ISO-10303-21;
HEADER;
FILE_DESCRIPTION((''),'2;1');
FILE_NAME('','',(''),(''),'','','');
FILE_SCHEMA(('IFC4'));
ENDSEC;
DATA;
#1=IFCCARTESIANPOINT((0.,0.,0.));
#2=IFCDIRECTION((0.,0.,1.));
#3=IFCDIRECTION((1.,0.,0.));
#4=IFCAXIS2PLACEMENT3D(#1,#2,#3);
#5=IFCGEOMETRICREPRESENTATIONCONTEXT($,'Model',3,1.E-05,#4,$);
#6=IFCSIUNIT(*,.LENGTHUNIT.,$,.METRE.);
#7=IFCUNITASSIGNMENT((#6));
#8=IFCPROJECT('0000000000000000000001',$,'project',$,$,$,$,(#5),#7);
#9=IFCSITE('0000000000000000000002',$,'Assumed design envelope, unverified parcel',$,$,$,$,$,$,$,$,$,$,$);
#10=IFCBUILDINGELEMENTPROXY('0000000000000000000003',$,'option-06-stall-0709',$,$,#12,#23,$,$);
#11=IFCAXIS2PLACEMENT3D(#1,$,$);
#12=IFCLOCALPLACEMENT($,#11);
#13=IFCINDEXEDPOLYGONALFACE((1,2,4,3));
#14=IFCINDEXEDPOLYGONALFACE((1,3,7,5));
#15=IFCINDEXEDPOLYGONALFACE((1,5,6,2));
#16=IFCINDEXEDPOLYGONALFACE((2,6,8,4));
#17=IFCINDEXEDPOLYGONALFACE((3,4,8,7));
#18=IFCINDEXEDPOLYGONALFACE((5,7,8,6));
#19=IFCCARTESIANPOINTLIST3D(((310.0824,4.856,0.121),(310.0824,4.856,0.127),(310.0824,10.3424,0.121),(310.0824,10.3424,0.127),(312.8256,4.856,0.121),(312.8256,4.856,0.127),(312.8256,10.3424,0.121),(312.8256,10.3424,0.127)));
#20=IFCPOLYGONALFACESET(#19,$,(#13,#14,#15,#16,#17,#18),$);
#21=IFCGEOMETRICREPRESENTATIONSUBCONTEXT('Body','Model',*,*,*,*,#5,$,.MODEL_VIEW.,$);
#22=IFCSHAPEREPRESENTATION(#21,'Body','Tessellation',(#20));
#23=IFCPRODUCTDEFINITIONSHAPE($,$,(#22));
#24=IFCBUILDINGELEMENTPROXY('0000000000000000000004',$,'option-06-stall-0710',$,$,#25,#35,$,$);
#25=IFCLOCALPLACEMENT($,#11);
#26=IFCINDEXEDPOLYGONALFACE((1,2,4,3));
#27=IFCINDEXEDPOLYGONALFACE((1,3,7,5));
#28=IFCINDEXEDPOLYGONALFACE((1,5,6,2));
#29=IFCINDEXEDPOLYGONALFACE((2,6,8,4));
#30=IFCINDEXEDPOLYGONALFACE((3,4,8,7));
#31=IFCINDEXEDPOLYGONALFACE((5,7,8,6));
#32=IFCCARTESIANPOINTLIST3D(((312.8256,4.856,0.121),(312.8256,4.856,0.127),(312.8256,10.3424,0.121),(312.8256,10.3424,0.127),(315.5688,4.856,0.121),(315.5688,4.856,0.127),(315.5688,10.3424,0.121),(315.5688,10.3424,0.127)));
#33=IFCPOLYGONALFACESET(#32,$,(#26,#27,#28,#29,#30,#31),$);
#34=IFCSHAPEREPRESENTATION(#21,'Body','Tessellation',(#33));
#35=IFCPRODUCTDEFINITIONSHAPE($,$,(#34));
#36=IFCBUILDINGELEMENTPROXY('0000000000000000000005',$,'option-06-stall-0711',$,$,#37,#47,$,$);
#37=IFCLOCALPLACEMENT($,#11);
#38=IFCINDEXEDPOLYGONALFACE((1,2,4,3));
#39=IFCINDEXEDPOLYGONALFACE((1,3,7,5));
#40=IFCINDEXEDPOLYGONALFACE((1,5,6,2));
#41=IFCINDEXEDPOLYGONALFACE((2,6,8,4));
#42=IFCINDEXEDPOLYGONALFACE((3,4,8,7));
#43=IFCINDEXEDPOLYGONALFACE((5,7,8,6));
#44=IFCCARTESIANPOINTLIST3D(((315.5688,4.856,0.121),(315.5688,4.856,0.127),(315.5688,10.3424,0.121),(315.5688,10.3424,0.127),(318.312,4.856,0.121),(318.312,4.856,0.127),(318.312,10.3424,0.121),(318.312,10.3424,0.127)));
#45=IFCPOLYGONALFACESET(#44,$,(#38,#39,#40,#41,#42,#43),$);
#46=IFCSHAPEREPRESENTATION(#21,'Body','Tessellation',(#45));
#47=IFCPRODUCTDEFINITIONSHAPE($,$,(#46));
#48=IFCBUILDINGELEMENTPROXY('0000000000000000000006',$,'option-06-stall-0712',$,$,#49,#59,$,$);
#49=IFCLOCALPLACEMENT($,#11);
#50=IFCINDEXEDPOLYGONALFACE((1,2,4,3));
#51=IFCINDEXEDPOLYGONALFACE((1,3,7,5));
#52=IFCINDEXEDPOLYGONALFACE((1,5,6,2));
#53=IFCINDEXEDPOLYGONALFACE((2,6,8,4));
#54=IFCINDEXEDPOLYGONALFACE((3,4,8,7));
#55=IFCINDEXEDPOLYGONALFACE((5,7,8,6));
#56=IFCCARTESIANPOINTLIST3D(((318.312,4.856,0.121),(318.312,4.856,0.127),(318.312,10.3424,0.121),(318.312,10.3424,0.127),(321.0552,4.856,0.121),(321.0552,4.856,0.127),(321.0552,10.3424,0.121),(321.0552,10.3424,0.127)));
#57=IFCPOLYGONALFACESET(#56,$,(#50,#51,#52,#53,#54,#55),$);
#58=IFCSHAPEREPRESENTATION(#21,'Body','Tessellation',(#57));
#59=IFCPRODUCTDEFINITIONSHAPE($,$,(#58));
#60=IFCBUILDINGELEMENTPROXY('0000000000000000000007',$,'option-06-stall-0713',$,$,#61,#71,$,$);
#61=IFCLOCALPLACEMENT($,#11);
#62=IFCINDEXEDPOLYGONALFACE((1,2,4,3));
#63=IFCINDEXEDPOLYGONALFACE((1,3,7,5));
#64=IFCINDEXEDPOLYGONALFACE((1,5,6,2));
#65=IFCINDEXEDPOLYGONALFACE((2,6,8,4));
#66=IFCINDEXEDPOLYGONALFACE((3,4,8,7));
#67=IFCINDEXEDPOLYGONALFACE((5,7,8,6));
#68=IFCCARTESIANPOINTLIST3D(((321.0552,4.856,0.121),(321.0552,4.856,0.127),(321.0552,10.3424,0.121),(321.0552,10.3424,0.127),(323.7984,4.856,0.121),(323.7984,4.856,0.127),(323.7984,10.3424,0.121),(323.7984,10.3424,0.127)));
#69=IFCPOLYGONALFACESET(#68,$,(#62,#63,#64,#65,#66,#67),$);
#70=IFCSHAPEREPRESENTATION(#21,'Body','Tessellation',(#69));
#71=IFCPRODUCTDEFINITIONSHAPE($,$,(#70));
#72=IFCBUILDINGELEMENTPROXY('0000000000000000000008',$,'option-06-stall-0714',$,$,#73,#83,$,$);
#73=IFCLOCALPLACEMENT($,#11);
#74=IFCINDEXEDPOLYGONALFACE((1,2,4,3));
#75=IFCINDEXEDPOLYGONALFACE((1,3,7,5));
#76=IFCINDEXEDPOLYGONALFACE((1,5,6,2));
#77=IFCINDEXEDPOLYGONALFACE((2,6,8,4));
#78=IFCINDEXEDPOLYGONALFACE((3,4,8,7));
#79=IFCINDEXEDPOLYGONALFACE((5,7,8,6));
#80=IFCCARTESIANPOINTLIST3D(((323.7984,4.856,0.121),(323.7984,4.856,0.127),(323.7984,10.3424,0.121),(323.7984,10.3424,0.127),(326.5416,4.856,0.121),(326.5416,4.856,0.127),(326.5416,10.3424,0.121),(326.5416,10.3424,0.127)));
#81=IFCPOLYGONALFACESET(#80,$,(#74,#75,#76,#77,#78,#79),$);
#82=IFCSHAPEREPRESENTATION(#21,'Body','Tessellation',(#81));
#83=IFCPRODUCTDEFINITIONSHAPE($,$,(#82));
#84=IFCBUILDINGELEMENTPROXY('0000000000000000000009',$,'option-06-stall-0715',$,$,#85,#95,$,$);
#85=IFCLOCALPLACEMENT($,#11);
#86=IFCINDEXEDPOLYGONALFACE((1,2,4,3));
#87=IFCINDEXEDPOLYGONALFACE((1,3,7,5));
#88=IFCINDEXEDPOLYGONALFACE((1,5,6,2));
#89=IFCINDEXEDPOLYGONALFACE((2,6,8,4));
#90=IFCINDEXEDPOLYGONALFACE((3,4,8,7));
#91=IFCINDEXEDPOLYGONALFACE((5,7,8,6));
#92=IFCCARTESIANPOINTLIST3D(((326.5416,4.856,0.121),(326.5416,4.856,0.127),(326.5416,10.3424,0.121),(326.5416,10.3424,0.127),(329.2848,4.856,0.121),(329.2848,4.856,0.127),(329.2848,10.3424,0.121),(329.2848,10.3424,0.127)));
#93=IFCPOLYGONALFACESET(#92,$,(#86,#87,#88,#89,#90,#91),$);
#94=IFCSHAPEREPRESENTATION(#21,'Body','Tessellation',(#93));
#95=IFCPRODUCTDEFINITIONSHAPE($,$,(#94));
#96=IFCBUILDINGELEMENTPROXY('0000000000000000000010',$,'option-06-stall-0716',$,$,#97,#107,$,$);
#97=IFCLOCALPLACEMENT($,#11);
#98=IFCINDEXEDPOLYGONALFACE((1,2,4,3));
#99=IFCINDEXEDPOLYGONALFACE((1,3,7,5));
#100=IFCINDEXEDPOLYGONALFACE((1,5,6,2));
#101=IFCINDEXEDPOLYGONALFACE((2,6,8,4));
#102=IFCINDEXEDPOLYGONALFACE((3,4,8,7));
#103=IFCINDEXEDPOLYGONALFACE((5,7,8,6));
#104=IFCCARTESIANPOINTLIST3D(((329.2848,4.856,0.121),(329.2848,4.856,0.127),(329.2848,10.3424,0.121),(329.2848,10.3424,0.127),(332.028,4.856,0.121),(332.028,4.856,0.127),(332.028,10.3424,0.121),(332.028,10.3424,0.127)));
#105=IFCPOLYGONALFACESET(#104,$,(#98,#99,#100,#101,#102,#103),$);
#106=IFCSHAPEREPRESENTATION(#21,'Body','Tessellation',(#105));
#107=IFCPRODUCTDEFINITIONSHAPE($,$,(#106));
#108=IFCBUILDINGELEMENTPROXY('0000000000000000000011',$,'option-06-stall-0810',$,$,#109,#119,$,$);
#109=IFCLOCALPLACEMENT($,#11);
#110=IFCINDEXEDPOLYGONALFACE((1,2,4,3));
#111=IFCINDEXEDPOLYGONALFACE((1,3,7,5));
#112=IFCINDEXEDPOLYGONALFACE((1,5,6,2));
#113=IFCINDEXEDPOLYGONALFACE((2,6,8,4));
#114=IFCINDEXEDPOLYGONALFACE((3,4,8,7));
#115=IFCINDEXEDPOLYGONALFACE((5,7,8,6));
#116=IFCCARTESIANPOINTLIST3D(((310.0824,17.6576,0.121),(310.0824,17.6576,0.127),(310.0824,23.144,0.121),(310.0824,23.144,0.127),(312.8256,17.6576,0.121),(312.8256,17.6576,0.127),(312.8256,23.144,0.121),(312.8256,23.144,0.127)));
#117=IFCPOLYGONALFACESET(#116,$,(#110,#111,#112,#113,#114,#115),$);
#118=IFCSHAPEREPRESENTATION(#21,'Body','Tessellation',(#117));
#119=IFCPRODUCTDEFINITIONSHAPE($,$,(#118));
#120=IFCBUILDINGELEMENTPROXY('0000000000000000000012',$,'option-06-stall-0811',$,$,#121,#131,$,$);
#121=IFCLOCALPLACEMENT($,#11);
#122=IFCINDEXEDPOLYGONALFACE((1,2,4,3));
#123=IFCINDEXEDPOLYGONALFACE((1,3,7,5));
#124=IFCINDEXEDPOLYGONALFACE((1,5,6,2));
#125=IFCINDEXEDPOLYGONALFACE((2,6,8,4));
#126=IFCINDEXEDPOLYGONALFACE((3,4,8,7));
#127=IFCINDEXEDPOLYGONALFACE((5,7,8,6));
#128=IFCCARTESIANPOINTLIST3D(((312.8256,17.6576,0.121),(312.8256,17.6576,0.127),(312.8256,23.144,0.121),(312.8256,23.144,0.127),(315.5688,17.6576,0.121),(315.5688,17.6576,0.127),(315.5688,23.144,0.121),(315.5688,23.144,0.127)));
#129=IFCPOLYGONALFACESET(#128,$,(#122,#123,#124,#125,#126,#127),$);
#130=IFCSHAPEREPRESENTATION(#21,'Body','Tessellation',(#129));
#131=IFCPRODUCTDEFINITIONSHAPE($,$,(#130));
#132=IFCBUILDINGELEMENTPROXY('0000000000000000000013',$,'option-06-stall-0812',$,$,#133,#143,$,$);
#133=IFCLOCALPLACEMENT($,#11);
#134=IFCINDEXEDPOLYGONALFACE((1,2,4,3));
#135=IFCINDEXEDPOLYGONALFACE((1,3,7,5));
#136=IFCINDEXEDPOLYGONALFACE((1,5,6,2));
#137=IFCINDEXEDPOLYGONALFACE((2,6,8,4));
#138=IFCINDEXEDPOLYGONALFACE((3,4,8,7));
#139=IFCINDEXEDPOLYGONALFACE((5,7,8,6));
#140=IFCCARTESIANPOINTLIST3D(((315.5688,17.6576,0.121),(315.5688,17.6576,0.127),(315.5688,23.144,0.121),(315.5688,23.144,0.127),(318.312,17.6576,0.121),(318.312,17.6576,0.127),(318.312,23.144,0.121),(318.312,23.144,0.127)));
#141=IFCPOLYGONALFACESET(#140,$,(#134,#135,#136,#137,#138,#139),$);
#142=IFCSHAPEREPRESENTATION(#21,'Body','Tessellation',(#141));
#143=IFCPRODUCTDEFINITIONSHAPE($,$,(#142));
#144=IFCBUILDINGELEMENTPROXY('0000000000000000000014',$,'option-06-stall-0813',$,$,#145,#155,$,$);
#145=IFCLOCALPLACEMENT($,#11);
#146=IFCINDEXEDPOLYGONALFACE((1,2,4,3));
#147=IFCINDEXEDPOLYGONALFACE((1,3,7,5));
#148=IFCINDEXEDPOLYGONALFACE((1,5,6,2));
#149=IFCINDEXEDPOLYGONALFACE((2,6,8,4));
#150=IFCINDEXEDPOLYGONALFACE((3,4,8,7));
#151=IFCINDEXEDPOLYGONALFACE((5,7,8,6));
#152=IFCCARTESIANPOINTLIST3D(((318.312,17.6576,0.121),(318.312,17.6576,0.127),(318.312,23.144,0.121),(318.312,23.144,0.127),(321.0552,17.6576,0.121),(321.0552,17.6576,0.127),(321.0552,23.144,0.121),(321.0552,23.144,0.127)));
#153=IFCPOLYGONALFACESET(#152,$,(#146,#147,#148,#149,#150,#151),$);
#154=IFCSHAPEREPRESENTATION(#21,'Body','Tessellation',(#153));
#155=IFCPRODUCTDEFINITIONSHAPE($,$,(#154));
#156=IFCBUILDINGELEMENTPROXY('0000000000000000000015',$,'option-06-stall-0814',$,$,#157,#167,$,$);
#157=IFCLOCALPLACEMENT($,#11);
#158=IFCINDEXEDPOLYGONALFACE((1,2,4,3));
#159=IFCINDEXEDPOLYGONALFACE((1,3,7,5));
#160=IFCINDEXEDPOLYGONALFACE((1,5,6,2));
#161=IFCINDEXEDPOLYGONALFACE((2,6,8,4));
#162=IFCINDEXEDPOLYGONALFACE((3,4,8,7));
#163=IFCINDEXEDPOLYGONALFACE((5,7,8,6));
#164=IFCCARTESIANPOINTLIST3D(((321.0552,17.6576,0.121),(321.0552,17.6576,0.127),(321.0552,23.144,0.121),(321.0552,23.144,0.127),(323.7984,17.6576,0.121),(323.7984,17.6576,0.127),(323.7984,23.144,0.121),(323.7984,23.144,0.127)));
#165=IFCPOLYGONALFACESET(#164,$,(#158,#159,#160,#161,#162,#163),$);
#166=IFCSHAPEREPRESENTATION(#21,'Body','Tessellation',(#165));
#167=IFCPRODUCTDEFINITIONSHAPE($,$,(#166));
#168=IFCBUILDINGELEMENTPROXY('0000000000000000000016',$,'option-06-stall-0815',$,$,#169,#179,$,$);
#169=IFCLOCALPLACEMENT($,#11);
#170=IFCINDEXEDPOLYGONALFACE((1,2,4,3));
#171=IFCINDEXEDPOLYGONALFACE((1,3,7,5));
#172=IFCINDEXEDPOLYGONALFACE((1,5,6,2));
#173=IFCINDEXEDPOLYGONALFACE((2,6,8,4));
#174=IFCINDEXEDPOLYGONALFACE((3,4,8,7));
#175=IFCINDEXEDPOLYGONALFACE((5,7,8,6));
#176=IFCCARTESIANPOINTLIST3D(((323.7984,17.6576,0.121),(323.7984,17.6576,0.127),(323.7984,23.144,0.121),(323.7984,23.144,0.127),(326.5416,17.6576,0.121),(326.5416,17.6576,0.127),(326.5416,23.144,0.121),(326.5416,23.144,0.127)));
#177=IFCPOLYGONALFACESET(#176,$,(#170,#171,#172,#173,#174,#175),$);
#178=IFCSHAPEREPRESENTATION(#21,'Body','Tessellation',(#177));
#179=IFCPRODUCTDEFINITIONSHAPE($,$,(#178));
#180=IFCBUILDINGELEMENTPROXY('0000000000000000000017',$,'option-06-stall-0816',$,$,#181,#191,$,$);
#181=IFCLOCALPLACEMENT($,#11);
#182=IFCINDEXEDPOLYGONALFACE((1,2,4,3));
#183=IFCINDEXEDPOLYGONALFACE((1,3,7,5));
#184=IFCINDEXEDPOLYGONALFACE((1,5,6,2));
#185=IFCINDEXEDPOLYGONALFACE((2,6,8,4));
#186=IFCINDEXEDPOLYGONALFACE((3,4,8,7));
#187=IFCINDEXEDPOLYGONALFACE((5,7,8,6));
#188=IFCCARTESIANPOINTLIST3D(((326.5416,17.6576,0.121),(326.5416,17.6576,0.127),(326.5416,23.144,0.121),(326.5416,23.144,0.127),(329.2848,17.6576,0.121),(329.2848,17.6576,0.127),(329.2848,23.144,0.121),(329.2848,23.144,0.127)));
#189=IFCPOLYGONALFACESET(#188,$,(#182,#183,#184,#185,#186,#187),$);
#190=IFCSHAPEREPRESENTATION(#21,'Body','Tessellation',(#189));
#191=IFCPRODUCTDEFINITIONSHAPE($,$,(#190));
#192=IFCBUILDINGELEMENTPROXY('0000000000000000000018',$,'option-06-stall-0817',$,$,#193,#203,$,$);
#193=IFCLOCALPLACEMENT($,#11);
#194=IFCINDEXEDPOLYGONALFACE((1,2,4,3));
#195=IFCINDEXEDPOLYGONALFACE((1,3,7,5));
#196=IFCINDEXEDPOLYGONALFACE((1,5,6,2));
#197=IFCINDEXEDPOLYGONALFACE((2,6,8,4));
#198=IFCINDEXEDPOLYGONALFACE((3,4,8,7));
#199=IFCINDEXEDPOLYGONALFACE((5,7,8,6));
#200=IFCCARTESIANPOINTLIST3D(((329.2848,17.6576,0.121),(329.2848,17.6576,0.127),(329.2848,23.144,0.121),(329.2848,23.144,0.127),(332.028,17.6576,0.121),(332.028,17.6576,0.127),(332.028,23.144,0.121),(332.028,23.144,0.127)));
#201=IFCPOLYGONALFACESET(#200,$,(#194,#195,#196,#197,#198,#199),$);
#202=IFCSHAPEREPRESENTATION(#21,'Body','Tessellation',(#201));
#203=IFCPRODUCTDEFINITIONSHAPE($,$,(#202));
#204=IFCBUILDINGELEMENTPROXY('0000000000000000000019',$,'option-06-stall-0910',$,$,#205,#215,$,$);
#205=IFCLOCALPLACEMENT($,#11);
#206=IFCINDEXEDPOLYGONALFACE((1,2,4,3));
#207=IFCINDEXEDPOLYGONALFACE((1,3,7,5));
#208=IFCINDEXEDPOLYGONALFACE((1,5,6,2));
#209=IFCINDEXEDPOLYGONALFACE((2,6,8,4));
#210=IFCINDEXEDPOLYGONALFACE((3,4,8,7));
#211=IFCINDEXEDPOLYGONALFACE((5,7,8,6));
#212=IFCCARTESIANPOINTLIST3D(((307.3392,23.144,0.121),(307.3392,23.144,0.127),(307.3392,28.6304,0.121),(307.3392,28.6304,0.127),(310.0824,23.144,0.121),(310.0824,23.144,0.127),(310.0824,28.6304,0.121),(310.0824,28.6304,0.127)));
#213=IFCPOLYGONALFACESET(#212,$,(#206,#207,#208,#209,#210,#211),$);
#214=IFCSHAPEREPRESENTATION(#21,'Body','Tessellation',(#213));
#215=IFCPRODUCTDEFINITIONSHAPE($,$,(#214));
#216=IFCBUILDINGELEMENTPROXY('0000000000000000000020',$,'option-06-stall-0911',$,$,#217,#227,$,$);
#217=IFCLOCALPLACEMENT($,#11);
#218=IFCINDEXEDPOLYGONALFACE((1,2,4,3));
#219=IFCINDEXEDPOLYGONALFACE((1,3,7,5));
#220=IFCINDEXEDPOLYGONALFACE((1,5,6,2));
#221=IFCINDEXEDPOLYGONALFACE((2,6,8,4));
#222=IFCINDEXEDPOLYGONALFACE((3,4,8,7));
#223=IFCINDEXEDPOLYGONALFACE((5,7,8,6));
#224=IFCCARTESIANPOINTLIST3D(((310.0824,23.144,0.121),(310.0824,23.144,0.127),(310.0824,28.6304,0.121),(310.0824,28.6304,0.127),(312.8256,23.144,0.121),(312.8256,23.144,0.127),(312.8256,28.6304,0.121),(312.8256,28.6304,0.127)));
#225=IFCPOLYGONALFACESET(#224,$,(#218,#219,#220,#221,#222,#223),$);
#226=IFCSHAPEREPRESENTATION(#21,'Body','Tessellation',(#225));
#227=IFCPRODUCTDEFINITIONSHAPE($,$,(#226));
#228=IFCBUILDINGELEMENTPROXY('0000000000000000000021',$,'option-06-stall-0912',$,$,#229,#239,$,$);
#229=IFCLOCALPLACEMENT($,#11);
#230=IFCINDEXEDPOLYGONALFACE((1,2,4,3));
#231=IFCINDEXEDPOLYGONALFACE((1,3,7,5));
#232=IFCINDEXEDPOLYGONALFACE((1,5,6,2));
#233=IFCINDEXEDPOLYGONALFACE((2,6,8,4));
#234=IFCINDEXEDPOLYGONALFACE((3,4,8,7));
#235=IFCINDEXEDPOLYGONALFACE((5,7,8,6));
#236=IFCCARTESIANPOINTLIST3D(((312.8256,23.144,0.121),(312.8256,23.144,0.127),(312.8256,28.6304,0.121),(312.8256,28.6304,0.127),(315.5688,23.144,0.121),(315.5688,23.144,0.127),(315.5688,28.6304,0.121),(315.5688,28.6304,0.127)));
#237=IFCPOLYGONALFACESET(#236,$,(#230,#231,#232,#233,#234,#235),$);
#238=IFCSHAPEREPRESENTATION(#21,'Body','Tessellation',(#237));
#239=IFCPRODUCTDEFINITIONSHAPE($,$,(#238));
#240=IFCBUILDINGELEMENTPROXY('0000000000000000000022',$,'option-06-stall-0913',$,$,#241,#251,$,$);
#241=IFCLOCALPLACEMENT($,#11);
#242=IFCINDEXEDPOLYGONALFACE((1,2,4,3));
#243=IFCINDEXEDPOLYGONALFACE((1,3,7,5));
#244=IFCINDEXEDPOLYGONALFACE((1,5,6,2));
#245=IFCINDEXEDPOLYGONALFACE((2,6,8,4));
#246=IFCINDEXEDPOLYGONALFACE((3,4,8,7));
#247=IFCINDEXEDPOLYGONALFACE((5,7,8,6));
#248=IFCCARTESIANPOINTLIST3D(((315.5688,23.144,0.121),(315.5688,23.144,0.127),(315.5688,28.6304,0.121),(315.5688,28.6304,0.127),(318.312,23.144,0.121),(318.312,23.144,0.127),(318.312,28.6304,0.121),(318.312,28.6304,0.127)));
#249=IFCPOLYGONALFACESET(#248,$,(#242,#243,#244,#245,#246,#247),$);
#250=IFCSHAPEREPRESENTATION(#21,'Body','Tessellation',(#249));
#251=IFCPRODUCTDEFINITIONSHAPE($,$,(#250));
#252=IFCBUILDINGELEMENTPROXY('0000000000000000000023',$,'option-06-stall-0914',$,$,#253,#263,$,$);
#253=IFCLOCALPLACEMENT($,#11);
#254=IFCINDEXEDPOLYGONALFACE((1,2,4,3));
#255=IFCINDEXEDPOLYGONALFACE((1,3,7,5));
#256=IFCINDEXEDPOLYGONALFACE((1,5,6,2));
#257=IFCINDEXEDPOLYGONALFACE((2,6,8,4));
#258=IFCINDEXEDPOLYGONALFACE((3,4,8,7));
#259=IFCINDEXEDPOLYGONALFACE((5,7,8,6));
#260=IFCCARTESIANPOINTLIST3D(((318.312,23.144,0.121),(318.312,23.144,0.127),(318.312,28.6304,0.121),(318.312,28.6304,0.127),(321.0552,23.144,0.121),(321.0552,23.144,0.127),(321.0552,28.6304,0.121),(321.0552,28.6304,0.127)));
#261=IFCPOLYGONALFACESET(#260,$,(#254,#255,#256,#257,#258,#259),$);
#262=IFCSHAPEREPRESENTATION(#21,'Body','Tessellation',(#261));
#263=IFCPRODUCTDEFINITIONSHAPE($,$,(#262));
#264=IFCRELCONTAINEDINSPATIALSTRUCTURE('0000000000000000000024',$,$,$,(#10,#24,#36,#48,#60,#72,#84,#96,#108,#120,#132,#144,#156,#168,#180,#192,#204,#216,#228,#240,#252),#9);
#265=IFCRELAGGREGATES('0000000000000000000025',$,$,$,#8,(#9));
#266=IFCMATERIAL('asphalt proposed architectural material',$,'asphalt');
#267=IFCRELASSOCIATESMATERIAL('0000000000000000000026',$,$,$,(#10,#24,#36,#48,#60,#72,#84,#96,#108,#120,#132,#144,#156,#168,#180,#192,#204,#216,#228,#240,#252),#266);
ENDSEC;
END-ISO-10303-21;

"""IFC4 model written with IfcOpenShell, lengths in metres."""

from ifc_helpers import new_model, si_unit, frame, origin_with_axes, place, context, subcontext, project, spatial, rectangle, extrude, material, element, save


model = new_model("IFC4")

# Units and contexts
model_context = context("Model", 3, precision=1e-05, world=origin_with_axes())
body_context = subcontext(model_context, "Body", "Model", "MODEL_VIEW")
ifc_project = project(units=[si_unit("LENGTHUNIT", "METRE")], contexts=[model_context])

# Site
site = spatial("IfcSite", under=ifc_project, Name="Assumed design envelope, unverified parcel")

# Building element proxies
ifc_material = material(Name="asphalt proposed architectural material", Category="asphalt")
for number, where, z_axis, x_axis, name in (
    (1, (311.454, 7.5992, 0.121), (0.0, 0.0, 1.0), (1.0, 0.0, 0.0), "option-06-stall-0709"),
    (2, (314.1972, 7.5992, 0.121), (0.0, 0.0, 1.0), (1.0, 0.0, 0.0), "option-06-stall-0710"),
    (3, (316.9404, 7.5992, 0.121), (0.0, 0.0, 1.0), (1.0, 0.0, 0.0), "option-06-stall-0711"),
    (4, (319.6836, 7.5992, 0.121), (0.0, 0.0, 1.0), (1.0, 0.0, 0.0), "option-06-stall-0712"),
    (5, (322.4268, 7.5992, 0.121), (0.0, 0.0, 1.0), (1.0, 0.0, 0.0), "option-06-stall-0713"),
    (6, (325.17, 7.5992, 0.121), (0.0, 0.0, 1.0), (1.0, 0.0, 0.0), "option-06-stall-0714"),
    (7, (327.9132, 7.5992, 0.121), (0.0, 0.0, 1.0), (1.0, 0.0, 0.0), "option-06-stall-0715"),
    (8, (330.6564, 7.5992, 0.121), (0.0, 0.0, 1.0), (1.0, 0.0, 0.0), "option-06-stall-0716"),
):
    element("IfcBuildingElementProxy", number, at=place(None, frame(where, z_axis=z_axis, x_axis=x_axis)), inside=site, material=ifc_material, Name=name, context=body_context, shape_type="SweptSolid", body=[
        extrude(rectangle(XDim=2.7432, YDim=5.4864), origin_with_axes(), (0.0, 0.0, 1.0), 0.006),
    ])
for number, where, z_axis, x_axis, name in (
    (9, (311.454, 20.4008, 0.121), (0.0, 0.0, 1.0), (1.0, 0.0, 0.0), "option-06-stall-0810"),
    (10, (314.1972, 20.4008, 0.121), (0.0, 0.0, 1.0), (1.0, 0.0, 0.0), "option-06-stall-0811"),
    (11, (316.9404, 20.4008, 0.121), (0.0, 0.0, 1.0), (1.0, 0.0, 0.0), "option-06-stall-0812"),
    (12, (319.6836, 20.4008, 0.121), (0.0, 0.0, 1.0), (1.0, 0.0, 0.0), "option-06-stall-0813"),
    (13, (322.4268, 20.4008, 0.121), (0.0, 0.0, 1.0), (1.0, 0.0, 0.0), "option-06-stall-0814"),
    (14, (325.17, 20.4008, 0.121), (0.0, 0.0, 1.0), (1.0, 0.0, 0.0), "option-06-stall-0815"),
    (15, (327.9132, 20.4008, 0.121), (0.0, 0.0, 1.0), (1.0, 0.0, 0.0), "option-06-stall-0816"),
    (16, (330.6564, 20.4008, 0.121), (0.0, 0.0, 1.0), (1.0, 0.0, 0.0), "option-06-stall-0817"),
    (17, (308.7108, 25.8872, 0.121), (0.0, 0.0, 1.0), (1.0, 0.0, 0.0), "option-06-stall-0910"),
    (18, (311.454, 25.8872, 0.121), (0.0, 0.0, 1.0), (1.0, 0.0, 0.0), "option-06-stall-0911"),
    (19, (314.1972, 25.8872, 0.121), (0.0, 0.0, 1.0), (1.0, 0.0, 0.0), "option-06-stall-0912"),
    (20, (316.9404, 25.8872, 0.121), (0.0, 0.0, 1.0), (1.0, 0.0, 0.0), "option-06-stall-0913"),
    (21, (319.6836, 25.8872, 0.121), (0.0, 0.0, 1.0), (1.0, 0.0, 0.0), "option-06-stall-0914"),
):
    element("IfcBuildingElementProxy", number, at=place(None, frame(where, z_axis=z_axis, x_axis=x_axis)), inside=site, material=ifc_material, Name=name, context=body_context, shape_type="SweptSolid", body=[
        extrude(rectangle(XDim=2.7432, YDim=5.4864), origin_with_axes(), (0.0, 0.0, 1.0), 0.006),
    ])

save(model, "model.ifc")
